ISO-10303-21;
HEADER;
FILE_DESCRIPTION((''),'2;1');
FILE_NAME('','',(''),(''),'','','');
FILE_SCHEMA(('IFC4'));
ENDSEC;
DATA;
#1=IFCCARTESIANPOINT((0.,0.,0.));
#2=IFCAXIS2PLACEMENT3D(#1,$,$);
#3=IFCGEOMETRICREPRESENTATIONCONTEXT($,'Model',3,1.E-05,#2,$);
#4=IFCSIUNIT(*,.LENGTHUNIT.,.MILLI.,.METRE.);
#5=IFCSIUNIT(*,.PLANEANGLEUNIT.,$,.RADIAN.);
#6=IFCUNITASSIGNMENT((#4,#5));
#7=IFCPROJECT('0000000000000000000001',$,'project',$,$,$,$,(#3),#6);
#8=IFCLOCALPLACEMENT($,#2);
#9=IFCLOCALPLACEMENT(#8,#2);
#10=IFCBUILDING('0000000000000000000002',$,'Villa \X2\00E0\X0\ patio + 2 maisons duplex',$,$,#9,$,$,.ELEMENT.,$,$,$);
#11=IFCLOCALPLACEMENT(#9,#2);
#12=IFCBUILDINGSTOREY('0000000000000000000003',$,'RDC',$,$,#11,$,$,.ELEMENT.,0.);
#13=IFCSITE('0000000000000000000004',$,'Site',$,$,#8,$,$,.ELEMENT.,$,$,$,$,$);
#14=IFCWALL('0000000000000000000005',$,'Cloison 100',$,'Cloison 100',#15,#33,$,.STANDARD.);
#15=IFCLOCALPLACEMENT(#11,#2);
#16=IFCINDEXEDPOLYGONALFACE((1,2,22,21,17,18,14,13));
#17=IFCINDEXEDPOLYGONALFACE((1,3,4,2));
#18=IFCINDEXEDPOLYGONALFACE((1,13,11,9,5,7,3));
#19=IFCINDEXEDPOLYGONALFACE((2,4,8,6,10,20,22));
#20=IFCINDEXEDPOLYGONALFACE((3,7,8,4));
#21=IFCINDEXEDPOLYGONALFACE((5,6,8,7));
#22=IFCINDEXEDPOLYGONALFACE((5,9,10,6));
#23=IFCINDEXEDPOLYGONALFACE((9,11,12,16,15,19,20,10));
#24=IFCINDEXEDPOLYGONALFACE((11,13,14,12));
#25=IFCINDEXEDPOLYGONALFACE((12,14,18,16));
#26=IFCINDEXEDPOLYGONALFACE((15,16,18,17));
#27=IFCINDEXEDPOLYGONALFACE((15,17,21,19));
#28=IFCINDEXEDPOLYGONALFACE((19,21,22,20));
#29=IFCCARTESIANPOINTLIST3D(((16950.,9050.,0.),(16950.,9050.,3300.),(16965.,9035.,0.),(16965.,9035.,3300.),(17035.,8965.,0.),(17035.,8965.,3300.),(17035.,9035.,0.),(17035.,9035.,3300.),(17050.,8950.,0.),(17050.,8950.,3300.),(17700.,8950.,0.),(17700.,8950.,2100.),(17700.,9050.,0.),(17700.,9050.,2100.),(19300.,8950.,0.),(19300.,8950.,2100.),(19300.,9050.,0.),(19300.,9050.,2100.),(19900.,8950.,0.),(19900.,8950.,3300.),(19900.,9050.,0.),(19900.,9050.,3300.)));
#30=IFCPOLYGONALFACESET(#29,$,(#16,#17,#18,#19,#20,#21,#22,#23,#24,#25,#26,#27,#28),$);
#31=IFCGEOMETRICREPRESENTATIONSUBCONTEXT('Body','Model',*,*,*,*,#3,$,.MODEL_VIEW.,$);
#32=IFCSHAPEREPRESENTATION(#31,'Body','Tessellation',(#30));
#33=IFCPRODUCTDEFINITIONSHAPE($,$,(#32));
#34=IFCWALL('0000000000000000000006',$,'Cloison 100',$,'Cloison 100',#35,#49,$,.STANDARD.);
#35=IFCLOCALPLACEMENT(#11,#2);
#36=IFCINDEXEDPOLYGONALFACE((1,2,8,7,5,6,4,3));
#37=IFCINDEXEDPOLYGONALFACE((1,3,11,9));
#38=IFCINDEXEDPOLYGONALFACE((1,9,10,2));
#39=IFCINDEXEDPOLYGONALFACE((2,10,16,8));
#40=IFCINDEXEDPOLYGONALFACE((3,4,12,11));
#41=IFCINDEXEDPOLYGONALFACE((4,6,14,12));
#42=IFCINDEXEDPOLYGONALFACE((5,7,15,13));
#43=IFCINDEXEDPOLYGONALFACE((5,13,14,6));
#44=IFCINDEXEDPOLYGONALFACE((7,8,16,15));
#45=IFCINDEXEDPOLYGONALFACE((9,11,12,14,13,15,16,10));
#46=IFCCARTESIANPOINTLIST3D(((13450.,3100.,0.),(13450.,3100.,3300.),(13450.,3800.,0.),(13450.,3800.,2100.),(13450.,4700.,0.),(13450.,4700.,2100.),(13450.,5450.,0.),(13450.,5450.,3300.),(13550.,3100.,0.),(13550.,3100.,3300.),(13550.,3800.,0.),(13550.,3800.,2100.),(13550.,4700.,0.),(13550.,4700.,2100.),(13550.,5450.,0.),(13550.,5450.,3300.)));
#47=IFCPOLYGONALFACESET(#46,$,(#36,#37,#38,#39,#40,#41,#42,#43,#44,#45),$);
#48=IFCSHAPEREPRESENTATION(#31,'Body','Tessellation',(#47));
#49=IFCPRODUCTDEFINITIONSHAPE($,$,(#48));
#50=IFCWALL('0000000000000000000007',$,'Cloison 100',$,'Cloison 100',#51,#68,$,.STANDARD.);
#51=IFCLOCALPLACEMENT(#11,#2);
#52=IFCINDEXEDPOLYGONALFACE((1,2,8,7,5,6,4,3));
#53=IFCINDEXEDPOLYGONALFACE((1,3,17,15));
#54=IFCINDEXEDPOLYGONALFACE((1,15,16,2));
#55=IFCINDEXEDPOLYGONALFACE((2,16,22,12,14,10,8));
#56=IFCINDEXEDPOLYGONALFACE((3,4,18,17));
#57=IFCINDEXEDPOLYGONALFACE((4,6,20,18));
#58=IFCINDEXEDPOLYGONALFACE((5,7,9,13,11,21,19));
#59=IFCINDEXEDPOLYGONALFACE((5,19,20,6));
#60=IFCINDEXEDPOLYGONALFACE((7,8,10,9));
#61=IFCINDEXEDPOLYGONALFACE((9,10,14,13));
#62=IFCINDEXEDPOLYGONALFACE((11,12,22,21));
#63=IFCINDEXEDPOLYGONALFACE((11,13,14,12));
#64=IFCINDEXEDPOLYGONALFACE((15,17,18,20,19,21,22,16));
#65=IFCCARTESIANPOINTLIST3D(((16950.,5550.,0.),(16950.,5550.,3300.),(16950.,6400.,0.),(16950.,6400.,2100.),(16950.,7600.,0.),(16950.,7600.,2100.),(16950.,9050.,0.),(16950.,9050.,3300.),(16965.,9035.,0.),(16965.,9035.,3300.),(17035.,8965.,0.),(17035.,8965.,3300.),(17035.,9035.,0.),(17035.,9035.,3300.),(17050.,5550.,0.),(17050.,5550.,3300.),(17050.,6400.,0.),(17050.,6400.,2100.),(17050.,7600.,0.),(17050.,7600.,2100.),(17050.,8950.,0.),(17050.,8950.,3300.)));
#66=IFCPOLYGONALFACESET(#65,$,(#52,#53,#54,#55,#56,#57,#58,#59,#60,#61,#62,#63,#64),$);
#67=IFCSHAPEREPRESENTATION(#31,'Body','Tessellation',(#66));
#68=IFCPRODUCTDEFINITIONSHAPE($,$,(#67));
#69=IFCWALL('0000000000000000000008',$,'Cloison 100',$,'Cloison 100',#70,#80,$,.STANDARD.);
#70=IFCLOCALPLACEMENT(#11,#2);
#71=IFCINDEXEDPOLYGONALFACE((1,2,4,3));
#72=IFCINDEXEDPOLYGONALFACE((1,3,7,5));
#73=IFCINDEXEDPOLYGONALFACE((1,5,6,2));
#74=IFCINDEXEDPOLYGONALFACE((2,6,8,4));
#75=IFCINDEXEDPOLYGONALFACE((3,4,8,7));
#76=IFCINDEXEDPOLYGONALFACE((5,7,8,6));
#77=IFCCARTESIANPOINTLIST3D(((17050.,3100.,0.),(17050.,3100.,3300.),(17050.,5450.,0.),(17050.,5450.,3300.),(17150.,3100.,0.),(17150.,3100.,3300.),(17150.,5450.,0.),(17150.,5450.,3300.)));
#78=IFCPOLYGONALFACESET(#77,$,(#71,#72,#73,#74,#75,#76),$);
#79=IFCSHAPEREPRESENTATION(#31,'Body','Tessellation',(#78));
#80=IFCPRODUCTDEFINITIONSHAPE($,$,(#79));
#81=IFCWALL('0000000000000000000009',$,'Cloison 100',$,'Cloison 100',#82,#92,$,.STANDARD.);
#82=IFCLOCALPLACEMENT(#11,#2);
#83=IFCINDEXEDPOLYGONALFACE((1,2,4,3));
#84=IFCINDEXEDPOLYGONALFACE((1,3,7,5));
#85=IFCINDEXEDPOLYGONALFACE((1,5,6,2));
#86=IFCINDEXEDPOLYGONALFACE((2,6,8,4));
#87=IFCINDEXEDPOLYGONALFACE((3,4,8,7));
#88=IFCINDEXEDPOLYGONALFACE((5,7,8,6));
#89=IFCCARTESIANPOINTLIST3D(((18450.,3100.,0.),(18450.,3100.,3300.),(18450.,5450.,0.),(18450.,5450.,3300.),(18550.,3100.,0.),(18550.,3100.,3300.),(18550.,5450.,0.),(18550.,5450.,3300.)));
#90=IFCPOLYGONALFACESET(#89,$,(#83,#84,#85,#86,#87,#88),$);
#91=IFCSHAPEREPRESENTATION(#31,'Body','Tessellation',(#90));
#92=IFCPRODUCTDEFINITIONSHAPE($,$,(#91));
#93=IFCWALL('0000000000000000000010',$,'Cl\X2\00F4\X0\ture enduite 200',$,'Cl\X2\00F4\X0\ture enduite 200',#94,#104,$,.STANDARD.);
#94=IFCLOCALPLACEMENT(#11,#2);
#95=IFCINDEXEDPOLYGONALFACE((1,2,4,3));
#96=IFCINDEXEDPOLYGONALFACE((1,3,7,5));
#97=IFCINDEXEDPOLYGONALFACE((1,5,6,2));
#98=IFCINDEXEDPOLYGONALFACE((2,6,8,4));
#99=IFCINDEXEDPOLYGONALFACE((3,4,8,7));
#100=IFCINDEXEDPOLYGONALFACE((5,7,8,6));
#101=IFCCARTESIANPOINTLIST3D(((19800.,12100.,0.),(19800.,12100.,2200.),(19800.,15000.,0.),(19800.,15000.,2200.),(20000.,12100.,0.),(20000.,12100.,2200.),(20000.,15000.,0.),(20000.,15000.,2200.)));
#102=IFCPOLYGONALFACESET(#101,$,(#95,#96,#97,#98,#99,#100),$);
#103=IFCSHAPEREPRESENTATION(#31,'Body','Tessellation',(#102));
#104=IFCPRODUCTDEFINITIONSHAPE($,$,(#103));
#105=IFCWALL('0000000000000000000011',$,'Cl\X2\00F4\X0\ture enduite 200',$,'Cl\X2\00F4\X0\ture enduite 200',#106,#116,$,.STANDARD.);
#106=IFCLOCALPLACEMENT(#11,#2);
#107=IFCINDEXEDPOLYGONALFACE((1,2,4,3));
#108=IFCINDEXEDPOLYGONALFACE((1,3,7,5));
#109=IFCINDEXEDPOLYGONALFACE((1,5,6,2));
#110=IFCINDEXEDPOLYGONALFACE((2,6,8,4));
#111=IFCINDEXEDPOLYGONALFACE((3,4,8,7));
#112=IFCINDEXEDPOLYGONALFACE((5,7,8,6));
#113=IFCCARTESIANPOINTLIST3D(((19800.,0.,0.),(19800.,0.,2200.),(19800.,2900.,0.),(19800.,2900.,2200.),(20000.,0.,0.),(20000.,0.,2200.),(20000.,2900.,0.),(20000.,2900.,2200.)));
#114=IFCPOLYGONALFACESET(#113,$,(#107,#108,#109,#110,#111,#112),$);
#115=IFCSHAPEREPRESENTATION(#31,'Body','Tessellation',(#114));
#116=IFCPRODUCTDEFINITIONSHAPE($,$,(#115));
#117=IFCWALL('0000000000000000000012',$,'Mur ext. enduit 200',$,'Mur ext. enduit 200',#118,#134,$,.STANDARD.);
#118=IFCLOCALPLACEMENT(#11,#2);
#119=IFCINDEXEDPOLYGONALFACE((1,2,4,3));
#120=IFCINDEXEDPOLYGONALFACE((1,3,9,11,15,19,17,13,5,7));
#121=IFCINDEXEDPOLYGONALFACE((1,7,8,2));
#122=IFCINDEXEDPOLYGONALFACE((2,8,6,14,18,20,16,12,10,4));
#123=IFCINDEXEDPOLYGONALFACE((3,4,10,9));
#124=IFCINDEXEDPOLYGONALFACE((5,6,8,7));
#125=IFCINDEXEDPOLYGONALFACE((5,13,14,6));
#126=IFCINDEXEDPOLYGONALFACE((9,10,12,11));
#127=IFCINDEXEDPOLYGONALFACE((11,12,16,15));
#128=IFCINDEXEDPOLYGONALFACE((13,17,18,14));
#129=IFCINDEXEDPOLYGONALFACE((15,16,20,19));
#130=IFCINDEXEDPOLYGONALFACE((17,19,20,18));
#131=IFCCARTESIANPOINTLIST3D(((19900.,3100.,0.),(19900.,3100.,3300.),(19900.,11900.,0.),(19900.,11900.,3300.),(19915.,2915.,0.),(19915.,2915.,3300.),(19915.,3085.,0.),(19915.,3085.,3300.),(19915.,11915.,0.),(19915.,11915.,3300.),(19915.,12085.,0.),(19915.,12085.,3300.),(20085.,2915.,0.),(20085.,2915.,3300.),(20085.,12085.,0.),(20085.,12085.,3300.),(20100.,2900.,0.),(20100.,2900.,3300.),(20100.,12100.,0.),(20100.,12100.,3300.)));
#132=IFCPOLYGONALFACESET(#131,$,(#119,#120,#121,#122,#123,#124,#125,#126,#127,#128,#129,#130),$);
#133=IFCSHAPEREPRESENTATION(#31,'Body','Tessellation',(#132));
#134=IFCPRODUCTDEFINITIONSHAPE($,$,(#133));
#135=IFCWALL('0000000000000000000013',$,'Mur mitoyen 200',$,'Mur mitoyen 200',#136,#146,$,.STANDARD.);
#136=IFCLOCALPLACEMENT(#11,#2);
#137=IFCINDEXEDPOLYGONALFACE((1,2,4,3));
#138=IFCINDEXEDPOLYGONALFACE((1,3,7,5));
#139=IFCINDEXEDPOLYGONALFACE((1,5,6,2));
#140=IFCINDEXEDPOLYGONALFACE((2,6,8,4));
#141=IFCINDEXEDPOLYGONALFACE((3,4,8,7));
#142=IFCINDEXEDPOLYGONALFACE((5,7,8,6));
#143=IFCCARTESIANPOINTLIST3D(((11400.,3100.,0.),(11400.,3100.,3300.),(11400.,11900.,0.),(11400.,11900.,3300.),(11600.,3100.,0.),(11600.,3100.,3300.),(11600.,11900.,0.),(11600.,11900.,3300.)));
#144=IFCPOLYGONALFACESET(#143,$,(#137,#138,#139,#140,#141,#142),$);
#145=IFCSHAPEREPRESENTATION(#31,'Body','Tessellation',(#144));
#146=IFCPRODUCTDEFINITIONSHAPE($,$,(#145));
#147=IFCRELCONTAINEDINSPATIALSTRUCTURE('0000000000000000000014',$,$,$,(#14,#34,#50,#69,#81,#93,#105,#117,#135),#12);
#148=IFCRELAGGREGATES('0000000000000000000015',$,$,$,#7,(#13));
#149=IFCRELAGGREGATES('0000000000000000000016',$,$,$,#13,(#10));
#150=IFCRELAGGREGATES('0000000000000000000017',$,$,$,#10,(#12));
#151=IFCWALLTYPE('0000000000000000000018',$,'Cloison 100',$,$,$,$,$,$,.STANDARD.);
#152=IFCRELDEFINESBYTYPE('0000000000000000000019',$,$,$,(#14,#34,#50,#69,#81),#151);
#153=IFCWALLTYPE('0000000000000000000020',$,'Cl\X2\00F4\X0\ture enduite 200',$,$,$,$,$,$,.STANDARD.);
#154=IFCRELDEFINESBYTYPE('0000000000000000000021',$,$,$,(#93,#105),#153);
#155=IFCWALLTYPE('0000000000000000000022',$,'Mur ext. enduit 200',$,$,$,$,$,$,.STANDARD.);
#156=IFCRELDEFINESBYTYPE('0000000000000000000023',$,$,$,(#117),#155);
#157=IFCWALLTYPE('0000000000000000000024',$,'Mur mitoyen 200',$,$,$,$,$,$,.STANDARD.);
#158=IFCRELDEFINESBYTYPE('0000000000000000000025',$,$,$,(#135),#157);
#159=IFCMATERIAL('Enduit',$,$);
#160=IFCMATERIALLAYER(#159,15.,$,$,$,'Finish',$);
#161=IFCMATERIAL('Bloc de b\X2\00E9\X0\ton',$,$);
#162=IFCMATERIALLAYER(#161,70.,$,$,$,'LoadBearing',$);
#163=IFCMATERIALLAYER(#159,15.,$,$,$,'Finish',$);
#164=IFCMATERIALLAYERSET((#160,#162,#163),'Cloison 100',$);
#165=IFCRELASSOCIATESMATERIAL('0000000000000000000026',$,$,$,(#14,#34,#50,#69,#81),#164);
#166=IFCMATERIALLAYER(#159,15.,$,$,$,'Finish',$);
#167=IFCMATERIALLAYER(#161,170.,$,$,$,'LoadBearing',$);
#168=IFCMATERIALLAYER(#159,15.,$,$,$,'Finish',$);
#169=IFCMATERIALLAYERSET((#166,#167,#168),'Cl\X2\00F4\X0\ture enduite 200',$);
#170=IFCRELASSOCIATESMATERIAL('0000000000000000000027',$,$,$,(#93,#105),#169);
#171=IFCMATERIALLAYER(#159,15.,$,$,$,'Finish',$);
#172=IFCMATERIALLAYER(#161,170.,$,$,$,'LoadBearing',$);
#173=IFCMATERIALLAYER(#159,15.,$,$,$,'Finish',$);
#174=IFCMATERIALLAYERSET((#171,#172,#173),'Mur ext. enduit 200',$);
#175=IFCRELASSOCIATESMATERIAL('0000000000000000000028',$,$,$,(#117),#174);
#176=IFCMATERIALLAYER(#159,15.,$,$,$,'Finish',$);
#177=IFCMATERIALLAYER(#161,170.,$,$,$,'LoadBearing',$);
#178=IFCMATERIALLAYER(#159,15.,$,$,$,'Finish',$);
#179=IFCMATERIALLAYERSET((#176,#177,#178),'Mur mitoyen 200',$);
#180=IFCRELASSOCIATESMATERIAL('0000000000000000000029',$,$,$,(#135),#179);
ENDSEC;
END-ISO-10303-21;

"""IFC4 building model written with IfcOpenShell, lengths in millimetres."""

from ifc_helpers import new_model, si_unit, frame, frame_2d, origin, place, context, subcontext, project, spatial, polyline, rectangle, outline, extrude, material, layer, layer_set, layer_usage, type_object, element, save


model = new_model("IFC4")

# Units and contexts
model_context = context("Model", 3, precision=1e-05, world=origin())
body_context = subcontext(model_context, "Body", "Model", "MODEL_VIEW")
ifc_project = project(units=[si_unit("LENGTHUNIT", "METRE", prefix="MILLI"), si_unit("PLANEANGLEUNIT", "RADIAN")], contexts=[model_context])

# Site, building, storey
site_placement = place(None, origin())
site = spatial("IfcSite", under=ifc_project, at=site_placement, Name="Site", CompositionType="ELEMENT")
building_placement = place(site_placement, origin())
building = spatial("IfcBuilding", under=site, at=building_placement, Name="Villa à patio + 2 maisons duplex", CompositionType="ELEMENT")
storey_placement = place(building_placement, origin())
storey = spatial("IfcBuildingStorey", under=building, at=storey_placement, Name="RDC", CompositionType="ELEMENT", Elevation=0.0)

# Walls, openings
ifc_material_1 = material(Name="Enduit")
ifc_layer_1 = layer(ifc_material_1, 15.0, Category="Finish")
ifc_material_2 = material(Name="Bloc de béton")
ifc_layer_2 = layer(ifc_material_2, 70.0, Category="LoadBearing")
ifc_layer_3 = layer(ifc_material_1, 15.0, Category="Finish")
ifc_layer_set_1 = layer_set([ifc_layer_1, ifc_layer_2, ifc_layer_3], Name="Cloison 100")
ifc_layer_usage_1 = layer_usage(ifc_layer_set_1, "AXIS2", "NEGATIVE", 50.0)
wall_type_1 = type_object("IfcWallType", Name="Cloison 100", PredefinedType="STANDARD")
wall_1_placement = place(storey_placement, frame((17000.0, 9000.0, 0.0), z_axis=(0.0, 0.0, 1.0), x_axis=(1.0, 0.0, 0.0)))
wall_1 = element("IfcWall", 1, at=wall_1_placement, inside=storey, type_object=wall_type_1, material=ifc_layer_usage_1, Name="Cloison 100", ObjectType="Cloison 100", PredefinedType="STANDARD", context=body_context, shape_type="SweptSolid", body=[
    extrude(outline(polyline([(50.0, -50.0), (35.0, -35.0), (35.0, 35.0), (-35.0, 35.0), (-50.0, 50.0), (2900.0, 50.0), (2900.0, -50.0), (50.0, -50.0)])), origin(), (0.0, 0.0, 1.0), 3300.0),
])
opening_1_placement = place(wall_1_placement, frame((700.0, 0.0, 0.0), z_axis=(0.0, 0.0, 1.0), x_axis=(1.0, 0.0, 0.0)))
element("IfcOpeningElement", 2, at=opening_1_placement, cuts=wall_1, PredefinedType="OPENING", context=body_context, shape_type="SweptSolid", body=[
    extrude(rectangle(XDim=1600.0, YDim=120.0, at=frame_2d((800.0, 0.0))), origin(), (0.0, 0.0, 1.0), 2100.0),
])
wall_2_placement = place(storey_placement, frame((13500.0, 5500.0, 0.0), z_axis=(0.0, 0.0, 1.0), x_axis=(0.0, -1.0, 0.0)))
wall_2 = element("IfcWall", 3, at=wall_2_placement, inside=storey, type_object=wall_type_1, material=ifc_layer_usage_1, Name="Cloison 100", ObjectType="Cloison 100", PredefinedType="STANDARD", context=body_context, shape_type="SweptSolid", body=[
    extrude(outline(polyline([(50.0, -50.0), (50.0, 50.0), (2400.0, 50.0), (2400.0, -50.0), (50.0, -50.0)])), origin(), (0.0, 0.0, 1.0), 3300.0),
])
opening_2_placement = place(wall_2_placement, frame((800.0, 0.0, 0.0), z_axis=(0.0, 0.0, 1.0), x_axis=(1.0, 0.0, 0.0)))
element("IfcOpeningElement", 4, at=opening_2_placement, cuts=wall_2, PredefinedType="OPENING", context=body_context, shape_type="SweptSolid", body=[
    extrude(rectangle(XDim=900.0, YDim=120.0, at=frame_2d((450.0, 0.0))), origin(), (0.0, 0.0, 1.0), 2100.0),
])
wall_3_placement = place(storey_placement, frame((17000.0, 9000.0, 0.0), z_axis=(0.0, 0.0, 1.0), x_axis=(0.0, -1.0, 0.0)))
wall_3 = element("IfcWall", 5, at=wall_3_placement, inside=storey, type_object=wall_type_1, material=ifc_layer_usage_1, Name="Cloison 100", ObjectType="Cloison 100", PredefinedType="STANDARD", context=body_context, shape_type="SweptSolid", body=[
    extrude(outline(polyline([(-50.0, -50.0), (-35.0, -35.0), (-35.0, 35.0), (35.0, 35.0), (50.0, 50.0), (3450.0, 50.0), (3450.0, -50.0), (-50.0, -50.0)])), origin(), (0.0, 0.0, 1.0), 3300.0),
])
opening_3_placement = place(wall_3_placement, frame((1400.0, 0.0, 0.0), z_axis=(0.0, 0.0, 1.0), x_axis=(1.0, 0.0, 0.0)))
element("IfcOpeningElement", 6, at=opening_3_placement, cuts=wall_3, PredefinedType="OPENING", context=body_context, shape_type="SweptSolid", body=[
    extrude(rectangle(XDim=1200.0, YDim=120.0, at=frame_2d((600.0, 0.0))), origin(), (0.0, 0.0, 1.0), 2100.0),
])

# Walls
for number, where, z_axis, x_axis, name in (
    (7, (17100.0, 5500.0, 0.0), (0.0, 0.0, 1.0), (0.0, -1.0, 0.0), "Cloison 100"),
    (8, (18500.0, 5500.0, 0.0), (0.0, 0.0, 1.0), (0.0, -1.0, 0.0), "Cloison 100"),
):
    element("IfcWall", number, at=place(storey_placement, frame(where, z_axis=z_axis, x_axis=x_axis)), inside=storey, type_object=wall_type_1, material=ifc_layer_usage_1, Name=name, ObjectType="Cloison 100", PredefinedType="STANDARD", context=body_context, shape_type="SweptSolid", body=[
        extrude(outline(polyline([(50.0, -50.0), (50.0, 50.0), (2400.0, 50.0), (2400.0, -50.0), (50.0, -50.0)])), origin(), (0.0, 0.0, 1.0), 3300.0),
    ])
ifc_layer_4 = layer(ifc_material_1, 15.0, Category="Finish")
ifc_layer_5 = layer(ifc_material_2, 170.0, Category="LoadBearing")
ifc_layer_6 = layer(ifc_material_1, 15.0, Category="Finish")
ifc_layer_set_2 = layer_set([ifc_layer_4, ifc_layer_5, ifc_layer_6], Name="Clôture enduite 200")
ifc_layer_usage_2 = layer_usage(ifc_layer_set_2, "AXIS2", "NEGATIVE", 100.0)
wall_type_2 = type_object("IfcWallType", Name="Clôture enduite 200", PredefinedType="STANDARD")
wall_4_placement = place(storey_placement, frame((19900.0, 15000.0, 0.0), z_axis=(0.0, 0.0, 1.0), x_axis=(0.0, -1.0, 0.0)))
element("IfcWall", 9, at=wall_4_placement, inside=storey, type_object=wall_type_2, material=ifc_layer_usage_2, Name="Clôture enduite 200", ObjectType="Clôture enduite 200", PredefinedType="STANDARD", context=body_context, shape_type="SweptSolid", body=[
    extrude(outline(polyline([(0.0, -100.0), (0.0, 100.0), (2900.0, 100.0), (2900.0, -100.0), (0.0, -100.0)])), origin(), (0.0, 0.0, 1.0), 2200.0),
])
wall_5_placement = place(storey_placement, frame((19900.0, 3000.0, 0.0), z_axis=(0.0, 0.0, 1.0), x_axis=(0.0, -1.0, 0.0)))
element("IfcWall", 10, at=wall_5_placement, inside=storey, type_object=wall_type_2, material=ifc_layer_usage_2, Name="Clôture enduite 200", ObjectType="Clôture enduite 200", PredefinedType="STANDARD", context=body_context, shape_type="SweptSolid", body=[
    extrude(outline(polyline([(100.0, -100.0), (100.0, 100.0), (3000.0, 100.0), (3000.0, -100.0), (100.0, -100.0)])), origin(), (0.0, 0.0, 1.0), 2200.0),
])
ifc_layer_7 = layer(ifc_material_1, 15.0, Category="Finish")
ifc_layer_8 = layer(ifc_material_2, 170.0, Category="LoadBearing")
ifc_layer_9 = layer(ifc_material_1, 15.0, Category="Finish")
ifc_layer_set_3 = layer_set([ifc_layer_7, ifc_layer_8, ifc_layer_9], Name="Mur ext. enduit 200")
ifc_layer_usage_3 = layer_usage(ifc_layer_set_3, "AXIS2", "NEGATIVE", 100.0)
wall_type_3 = type_object("IfcWallType", Name="Mur ext. enduit 200", PredefinedType="STANDARD")
wall_6_placement = place(storey_placement, frame((20000.0, 12000.0, 0.0), z_axis=(0.0, 0.0, 1.0), x_axis=(0.0, -1.0, 0.0)))
element("IfcWall", 11, at=wall_6_placement, inside=storey, type_object=wall_type_3, material=ifc_layer_usage_3, Name="Mur ext. enduit 200", ObjectType="Mur ext. enduit 200", PredefinedType="STANDARD", context=body_context, shape_type="SweptSolid", body=[
    extrude(outline(polyline([(100.0, -100.0), (85.0, -85.0), (-85.0, -85.0), (-85.0, 85.0), (-100.0, 100.0), (9100.0, 100.0), (9085.0, 85.0), (9085.0, -85.0), (8915.0, -85.0), (8900.0, -100.0), (100.0, -100.0)])), origin(), (0.0, 0.0, 1.0), 3300.0),
])
ifc_layer_10 = layer(ifc_material_1, 15.0, Category="Finish")
ifc_layer_11 = layer(ifc_material_2, 170.0, Category="LoadBearing")
ifc_layer_12 = layer(ifc_material_1, 15.0, Category="Finish")
ifc_layer_set_4 = layer_set([ifc_layer_10, ifc_layer_11, ifc_layer_12], Name="Mur mitoyen 200")
ifc_layer_usage_4 = layer_usage(ifc_layer_set_4, "AXIS2", "NEGATIVE", 100.0)
wall_type_4 = type_object("IfcWallType", Name="Mur mitoyen 200", PredefinedType="STANDARD")
wall_7_placement = place(storey_placement, frame((11500.0, 12000.0, 0.0), z_axis=(0.0, 0.0, 1.0), x_axis=(0.0, -1.0, 0.0)))
element("IfcWall", 12, at=wall_7_placement, inside=storey, type_object=wall_type_4, material=ifc_layer_usage_4, Name="Mur mitoyen 200", ObjectType="Mur mitoyen 200", PredefinedType="STANDARD", context=body_context, shape_type="SweptSolid", body=[
    extrude(outline(polyline([(100.0, -100.0), (100.0, 100.0), (8900.0, 100.0), (8900.0, -100.0), (100.0, -100.0)])), origin(), (0.0, 0.0, 1.0), 3300.0),
])

save(model, "model.ifc")
